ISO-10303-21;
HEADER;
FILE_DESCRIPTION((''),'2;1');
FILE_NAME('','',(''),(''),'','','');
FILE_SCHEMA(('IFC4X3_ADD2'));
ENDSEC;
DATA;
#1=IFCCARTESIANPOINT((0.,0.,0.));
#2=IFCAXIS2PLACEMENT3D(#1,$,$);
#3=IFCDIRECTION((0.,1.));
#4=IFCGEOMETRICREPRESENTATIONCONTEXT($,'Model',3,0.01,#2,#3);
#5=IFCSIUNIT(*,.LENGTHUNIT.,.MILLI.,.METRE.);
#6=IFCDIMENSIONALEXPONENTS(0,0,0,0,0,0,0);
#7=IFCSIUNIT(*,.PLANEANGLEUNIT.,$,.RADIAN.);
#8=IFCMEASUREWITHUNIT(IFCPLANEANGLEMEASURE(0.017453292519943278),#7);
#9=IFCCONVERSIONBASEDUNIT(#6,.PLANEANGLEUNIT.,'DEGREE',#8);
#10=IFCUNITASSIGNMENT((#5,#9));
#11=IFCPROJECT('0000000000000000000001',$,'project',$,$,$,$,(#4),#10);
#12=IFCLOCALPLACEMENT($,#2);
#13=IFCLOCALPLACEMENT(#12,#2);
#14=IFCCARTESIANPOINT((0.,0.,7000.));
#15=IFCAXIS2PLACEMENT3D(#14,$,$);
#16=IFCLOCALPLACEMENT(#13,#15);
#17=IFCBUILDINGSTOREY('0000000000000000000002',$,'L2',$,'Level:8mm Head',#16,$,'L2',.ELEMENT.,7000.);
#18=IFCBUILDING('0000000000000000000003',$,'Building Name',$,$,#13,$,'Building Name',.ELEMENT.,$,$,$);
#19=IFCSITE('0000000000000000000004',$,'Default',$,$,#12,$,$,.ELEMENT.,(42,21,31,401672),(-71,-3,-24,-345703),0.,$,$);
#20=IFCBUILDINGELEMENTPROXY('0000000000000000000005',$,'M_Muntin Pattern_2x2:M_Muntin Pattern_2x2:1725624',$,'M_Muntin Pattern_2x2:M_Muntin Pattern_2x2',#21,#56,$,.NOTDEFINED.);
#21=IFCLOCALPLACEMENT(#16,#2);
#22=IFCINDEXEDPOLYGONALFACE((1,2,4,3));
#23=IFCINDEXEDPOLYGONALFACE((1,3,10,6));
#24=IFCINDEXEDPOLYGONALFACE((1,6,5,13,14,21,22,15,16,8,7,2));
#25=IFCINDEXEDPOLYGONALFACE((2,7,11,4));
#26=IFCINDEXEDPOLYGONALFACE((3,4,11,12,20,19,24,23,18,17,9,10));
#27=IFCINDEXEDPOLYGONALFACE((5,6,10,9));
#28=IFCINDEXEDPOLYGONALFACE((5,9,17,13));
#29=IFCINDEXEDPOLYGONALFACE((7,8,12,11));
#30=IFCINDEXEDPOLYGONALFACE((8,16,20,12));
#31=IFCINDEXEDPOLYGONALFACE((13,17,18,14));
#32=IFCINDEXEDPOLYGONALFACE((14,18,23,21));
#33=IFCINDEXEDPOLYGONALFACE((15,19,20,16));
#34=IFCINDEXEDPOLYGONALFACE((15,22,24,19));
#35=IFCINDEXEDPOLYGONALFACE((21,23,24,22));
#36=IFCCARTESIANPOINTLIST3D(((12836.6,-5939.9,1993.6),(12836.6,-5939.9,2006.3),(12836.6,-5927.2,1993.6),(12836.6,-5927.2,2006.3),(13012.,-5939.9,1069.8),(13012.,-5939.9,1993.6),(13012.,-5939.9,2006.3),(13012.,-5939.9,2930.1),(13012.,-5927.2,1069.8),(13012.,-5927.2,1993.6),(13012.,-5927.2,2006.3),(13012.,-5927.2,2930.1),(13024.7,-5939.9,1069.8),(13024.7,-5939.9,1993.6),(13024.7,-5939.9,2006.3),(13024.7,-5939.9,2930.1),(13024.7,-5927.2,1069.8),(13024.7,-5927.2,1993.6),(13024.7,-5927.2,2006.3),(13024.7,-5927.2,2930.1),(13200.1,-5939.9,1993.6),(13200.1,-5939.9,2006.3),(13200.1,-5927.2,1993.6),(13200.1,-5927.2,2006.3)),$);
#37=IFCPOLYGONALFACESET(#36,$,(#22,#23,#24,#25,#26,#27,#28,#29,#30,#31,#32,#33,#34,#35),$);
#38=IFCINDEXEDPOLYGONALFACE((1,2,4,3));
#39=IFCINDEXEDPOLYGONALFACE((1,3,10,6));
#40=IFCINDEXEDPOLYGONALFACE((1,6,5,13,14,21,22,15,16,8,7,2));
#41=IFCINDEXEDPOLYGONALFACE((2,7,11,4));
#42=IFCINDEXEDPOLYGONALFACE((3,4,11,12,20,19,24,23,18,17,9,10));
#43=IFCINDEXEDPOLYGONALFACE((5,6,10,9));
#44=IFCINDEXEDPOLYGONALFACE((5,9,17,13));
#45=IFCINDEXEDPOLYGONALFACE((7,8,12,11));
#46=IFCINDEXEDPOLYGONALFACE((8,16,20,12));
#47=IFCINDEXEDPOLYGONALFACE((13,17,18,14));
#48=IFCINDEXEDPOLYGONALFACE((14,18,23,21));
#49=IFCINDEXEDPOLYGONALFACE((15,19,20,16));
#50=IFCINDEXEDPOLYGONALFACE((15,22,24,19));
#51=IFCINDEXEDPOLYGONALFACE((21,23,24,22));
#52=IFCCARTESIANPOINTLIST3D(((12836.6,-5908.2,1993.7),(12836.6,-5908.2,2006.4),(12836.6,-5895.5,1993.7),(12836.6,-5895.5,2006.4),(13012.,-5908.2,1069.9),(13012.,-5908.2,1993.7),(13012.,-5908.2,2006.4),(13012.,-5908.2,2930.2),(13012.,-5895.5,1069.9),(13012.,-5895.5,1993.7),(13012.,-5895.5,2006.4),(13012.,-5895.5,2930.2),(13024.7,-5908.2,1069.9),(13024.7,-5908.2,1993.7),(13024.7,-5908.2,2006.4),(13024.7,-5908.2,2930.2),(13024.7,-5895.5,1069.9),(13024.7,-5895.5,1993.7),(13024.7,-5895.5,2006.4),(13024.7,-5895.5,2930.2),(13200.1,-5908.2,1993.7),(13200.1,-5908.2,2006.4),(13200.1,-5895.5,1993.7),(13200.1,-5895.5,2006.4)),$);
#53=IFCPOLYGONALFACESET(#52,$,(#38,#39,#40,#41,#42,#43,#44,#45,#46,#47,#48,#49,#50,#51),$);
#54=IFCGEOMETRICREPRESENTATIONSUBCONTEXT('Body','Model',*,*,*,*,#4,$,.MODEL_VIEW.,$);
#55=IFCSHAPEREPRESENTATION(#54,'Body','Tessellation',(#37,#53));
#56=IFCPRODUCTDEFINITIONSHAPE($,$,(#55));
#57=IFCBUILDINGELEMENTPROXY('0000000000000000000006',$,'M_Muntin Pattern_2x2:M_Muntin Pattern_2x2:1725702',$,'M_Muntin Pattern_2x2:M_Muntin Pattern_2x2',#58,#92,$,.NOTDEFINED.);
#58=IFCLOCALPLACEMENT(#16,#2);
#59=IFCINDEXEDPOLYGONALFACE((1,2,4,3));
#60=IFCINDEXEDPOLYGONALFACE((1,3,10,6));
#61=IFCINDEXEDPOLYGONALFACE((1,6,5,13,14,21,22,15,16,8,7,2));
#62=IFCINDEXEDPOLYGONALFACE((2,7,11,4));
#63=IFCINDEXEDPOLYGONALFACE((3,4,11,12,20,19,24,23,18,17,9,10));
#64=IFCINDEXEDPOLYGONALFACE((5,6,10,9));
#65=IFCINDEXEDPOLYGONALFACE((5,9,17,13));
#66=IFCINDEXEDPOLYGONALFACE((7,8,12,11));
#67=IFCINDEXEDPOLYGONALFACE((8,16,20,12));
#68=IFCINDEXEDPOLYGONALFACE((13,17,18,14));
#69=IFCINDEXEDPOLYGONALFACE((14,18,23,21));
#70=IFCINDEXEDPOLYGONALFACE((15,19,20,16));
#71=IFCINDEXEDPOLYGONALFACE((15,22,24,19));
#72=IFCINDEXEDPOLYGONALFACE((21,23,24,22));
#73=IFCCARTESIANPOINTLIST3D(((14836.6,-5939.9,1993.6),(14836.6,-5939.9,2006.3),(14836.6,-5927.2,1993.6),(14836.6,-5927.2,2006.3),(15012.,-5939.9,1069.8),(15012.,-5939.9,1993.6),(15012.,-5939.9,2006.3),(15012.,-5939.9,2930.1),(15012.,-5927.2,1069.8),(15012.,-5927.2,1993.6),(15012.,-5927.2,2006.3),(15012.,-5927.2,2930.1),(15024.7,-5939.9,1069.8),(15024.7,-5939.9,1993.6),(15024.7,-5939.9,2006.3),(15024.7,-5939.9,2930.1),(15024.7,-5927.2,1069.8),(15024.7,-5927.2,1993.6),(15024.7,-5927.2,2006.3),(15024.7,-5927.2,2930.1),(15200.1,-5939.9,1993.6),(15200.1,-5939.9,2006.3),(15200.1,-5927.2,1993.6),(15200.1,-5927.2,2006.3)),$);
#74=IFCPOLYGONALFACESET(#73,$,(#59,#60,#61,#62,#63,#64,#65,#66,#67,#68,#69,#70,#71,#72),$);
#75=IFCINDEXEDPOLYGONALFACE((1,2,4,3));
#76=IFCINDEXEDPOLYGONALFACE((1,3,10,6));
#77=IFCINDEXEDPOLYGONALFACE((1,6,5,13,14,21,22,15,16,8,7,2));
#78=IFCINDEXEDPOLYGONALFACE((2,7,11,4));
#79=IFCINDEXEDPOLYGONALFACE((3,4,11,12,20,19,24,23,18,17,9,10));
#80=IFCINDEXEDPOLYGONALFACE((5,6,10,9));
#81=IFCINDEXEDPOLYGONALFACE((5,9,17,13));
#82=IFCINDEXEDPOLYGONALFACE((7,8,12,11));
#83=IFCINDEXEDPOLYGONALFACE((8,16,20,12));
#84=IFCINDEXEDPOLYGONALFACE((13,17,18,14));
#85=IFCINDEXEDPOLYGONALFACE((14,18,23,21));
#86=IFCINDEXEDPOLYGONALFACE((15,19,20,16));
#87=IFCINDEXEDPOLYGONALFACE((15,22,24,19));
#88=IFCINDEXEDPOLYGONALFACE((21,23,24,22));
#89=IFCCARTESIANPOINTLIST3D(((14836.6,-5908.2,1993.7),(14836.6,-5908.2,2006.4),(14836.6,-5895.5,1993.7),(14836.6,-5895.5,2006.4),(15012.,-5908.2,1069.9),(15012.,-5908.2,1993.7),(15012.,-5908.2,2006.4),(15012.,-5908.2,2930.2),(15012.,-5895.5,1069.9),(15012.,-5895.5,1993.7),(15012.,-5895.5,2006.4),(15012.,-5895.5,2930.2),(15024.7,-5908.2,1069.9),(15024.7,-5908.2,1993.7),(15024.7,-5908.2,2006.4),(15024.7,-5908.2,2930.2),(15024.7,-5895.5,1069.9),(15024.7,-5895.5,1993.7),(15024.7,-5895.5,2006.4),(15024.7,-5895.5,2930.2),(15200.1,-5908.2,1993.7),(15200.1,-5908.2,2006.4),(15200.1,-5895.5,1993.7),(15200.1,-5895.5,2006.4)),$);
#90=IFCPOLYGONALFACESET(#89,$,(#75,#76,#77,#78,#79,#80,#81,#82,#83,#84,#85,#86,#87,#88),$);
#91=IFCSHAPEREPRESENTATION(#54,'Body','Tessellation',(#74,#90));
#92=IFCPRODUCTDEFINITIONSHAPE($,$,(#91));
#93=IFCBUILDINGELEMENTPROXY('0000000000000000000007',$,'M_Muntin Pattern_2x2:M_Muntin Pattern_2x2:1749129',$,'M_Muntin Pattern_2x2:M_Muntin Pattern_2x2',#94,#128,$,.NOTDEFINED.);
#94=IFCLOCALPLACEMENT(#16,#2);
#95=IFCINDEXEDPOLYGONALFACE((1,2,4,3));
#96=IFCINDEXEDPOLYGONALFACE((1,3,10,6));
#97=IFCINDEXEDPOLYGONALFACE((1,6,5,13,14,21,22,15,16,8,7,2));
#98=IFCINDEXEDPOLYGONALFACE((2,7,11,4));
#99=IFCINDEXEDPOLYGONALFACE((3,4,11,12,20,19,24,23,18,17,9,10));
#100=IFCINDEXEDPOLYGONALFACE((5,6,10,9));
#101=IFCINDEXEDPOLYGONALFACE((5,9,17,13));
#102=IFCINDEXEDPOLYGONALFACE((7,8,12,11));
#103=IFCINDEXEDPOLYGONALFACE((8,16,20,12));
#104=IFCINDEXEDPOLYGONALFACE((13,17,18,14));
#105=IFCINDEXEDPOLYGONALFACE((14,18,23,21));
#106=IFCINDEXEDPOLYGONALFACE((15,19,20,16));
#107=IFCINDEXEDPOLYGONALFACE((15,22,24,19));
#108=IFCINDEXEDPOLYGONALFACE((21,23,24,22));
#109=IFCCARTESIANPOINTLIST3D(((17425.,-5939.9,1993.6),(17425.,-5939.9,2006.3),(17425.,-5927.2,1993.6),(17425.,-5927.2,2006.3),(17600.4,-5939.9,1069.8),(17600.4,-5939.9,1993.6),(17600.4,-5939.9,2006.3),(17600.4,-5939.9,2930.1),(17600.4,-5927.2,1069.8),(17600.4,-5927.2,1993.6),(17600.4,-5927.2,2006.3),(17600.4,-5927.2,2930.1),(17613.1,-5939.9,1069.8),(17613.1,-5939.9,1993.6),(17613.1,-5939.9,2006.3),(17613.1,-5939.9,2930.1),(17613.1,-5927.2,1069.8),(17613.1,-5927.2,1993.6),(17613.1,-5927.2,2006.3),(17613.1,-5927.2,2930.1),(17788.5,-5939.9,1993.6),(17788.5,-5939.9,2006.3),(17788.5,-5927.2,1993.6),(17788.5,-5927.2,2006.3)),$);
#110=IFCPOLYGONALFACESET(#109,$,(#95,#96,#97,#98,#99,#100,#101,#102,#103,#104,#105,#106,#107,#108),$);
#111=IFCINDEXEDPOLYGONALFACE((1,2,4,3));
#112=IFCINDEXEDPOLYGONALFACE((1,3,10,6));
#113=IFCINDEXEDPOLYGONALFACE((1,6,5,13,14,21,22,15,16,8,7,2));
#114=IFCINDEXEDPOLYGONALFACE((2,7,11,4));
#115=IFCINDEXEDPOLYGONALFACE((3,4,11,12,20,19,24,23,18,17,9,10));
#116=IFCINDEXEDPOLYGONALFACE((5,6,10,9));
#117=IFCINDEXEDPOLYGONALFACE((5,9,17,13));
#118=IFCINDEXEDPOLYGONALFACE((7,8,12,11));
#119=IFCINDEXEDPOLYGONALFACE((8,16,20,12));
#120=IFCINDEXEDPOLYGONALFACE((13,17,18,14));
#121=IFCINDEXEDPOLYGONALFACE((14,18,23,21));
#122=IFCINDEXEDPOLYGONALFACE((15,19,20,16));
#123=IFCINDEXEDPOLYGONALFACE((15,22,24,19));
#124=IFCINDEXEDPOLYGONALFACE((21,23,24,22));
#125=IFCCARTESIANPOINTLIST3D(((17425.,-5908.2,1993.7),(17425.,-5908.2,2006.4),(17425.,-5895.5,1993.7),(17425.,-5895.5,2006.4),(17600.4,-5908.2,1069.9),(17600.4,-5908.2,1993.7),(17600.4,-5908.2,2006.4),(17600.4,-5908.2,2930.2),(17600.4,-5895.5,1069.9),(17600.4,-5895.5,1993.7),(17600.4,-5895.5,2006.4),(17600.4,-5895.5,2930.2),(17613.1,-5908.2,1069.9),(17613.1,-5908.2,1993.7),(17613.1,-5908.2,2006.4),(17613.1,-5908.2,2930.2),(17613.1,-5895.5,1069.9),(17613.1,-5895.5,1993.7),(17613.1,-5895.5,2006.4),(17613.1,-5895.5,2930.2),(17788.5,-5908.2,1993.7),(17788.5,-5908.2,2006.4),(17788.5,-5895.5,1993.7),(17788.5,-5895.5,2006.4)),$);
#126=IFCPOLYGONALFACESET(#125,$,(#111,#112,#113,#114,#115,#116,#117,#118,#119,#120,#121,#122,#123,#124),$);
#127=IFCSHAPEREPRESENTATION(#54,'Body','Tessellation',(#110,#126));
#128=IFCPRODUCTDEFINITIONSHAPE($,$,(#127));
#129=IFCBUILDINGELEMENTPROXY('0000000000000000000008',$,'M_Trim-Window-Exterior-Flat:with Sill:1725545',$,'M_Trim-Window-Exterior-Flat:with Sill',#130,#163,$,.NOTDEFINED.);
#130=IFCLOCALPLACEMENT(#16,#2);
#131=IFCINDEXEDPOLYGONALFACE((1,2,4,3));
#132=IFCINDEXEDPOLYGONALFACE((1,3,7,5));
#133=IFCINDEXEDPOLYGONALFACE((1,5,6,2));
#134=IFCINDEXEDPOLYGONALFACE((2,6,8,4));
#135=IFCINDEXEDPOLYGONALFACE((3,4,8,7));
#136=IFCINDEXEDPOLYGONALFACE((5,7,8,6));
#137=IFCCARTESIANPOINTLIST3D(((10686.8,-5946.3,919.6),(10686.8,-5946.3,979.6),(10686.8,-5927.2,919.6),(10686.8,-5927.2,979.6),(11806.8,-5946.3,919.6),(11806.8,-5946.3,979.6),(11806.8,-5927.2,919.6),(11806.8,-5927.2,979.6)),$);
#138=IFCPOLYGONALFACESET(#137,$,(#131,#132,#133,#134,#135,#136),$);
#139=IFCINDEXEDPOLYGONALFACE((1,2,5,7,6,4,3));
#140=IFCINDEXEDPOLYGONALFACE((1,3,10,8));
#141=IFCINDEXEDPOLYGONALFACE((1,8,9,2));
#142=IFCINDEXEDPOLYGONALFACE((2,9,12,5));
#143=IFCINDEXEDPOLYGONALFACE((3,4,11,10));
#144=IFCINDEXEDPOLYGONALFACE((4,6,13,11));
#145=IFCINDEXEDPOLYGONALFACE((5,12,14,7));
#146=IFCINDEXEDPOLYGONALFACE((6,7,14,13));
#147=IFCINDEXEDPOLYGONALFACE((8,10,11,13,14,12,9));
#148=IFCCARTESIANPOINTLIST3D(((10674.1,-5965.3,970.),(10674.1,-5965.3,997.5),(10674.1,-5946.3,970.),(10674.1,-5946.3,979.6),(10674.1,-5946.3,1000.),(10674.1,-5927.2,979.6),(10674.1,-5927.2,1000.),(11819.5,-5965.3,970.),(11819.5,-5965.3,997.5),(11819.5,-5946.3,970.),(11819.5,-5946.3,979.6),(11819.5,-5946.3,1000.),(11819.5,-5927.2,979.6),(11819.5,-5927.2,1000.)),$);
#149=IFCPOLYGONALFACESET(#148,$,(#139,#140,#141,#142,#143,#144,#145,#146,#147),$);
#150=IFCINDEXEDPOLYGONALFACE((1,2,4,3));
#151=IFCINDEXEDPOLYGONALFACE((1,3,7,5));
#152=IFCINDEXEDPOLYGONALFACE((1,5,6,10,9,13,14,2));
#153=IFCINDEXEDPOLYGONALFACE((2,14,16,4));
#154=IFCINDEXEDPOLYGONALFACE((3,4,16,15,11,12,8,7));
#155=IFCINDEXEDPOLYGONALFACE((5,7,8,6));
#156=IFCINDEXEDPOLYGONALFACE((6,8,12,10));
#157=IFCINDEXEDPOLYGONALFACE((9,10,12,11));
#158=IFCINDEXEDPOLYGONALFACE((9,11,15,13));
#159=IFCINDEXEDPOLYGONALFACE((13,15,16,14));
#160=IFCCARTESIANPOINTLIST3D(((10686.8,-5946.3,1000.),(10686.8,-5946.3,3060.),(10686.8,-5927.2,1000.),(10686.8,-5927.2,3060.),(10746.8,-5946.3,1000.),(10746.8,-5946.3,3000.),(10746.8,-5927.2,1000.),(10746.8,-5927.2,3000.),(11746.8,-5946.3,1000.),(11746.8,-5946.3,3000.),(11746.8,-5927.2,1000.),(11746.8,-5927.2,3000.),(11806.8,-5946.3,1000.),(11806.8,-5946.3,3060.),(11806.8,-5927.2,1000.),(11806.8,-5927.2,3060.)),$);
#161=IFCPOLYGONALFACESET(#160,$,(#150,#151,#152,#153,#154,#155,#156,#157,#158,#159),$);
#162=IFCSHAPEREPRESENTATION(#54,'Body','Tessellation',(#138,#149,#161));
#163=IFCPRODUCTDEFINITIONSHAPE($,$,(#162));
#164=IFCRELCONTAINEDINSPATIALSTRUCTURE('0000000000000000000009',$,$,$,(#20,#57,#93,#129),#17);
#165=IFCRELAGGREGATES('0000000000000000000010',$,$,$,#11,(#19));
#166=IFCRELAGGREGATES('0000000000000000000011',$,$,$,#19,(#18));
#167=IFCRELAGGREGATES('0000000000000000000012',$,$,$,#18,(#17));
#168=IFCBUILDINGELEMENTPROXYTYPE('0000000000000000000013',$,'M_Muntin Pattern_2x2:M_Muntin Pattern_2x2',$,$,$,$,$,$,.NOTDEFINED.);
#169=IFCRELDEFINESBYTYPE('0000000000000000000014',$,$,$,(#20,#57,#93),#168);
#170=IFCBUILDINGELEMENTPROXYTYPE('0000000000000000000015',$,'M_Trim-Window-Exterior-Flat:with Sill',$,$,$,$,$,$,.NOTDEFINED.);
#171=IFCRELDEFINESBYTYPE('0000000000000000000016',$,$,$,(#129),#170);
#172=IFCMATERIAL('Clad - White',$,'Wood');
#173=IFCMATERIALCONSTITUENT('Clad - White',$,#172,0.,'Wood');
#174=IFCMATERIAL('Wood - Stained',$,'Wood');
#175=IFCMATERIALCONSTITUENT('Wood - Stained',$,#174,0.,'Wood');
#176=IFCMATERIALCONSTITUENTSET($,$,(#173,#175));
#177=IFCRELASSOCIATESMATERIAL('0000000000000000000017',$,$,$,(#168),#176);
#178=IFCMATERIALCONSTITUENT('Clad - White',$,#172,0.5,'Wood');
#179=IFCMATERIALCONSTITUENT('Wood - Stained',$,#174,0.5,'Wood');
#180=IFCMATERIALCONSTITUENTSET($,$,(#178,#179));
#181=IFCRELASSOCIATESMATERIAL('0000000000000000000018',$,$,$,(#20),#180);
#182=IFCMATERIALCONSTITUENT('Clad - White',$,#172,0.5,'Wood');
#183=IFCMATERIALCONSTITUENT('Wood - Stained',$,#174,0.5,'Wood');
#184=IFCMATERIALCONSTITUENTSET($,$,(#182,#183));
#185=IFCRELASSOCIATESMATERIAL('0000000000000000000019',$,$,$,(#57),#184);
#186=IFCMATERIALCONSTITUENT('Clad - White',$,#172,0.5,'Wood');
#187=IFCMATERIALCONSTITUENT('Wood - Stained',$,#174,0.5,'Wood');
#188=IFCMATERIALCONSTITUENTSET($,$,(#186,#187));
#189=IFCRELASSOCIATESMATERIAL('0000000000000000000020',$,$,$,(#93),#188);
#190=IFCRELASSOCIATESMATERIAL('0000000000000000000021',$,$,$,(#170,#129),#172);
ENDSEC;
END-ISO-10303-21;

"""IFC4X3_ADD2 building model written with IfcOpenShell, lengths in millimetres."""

from ifc_helpers import new_model, entity, si_unit, converted_unit, direction, frame, frame_2d, origin, place, context, subcontext, project, spatial, polyline, rectangle, outline, extrude, source, transform, mapped, material, constituent, constituent_set, type_object, type_shapes, element, save


model = new_model("IFC4X3_ADD2")

# Units and contexts
model_context = context("Model", 3, precision=0.01, world=origin(), true_north=direction((0.0, 1.0)))
body_context = subcontext(model_context, "Body", "Model", "MODEL_VIEW")
ifc_project = project(units=[si_unit("LENGTHUNIT", "METRE", prefix="MILLI"), converted_unit("PLANEANGLEUNIT", "DEGREE", entity("IfcPlaneAngleMeasure", 0.017453292519943278), si_unit("PLANEANGLEUNIT", "RADIAN"), dimensions=[0, 0, 0, 0, 0, 0, 0])], contexts=[model_context])

# Site, building, storey
site_placement = place(None, origin())
site = spatial("IfcSite", under=ifc_project, at=site_placement, Name="Default", CompositionType="ELEMENT", RefLatitude=(42, 21, 31, 401672), RefLongitude=(-71, -3, -24, -345703), RefElevation=0.0)
building_placement = place(site_placement, origin())
building = spatial("IfcBuilding", under=site, at=building_placement, Name="Building Name", LongName="Building Name", CompositionType="ELEMENT")
storey_placement = place(building_placement, frame((0.0, 0.0, 7000.0)))
storey = spatial("IfcBuildingStorey", under=building, at=storey_placement, Name="L2", ObjectType="Level:8mm Head", LongName="L2", CompositionType="ELEMENT", Elevation=7000.0)

# Building element proxies
ifc_material_1 = material(Name="Clad - White", Category="Wood")
ifc_material_2 = material(Name="Wood - Stained", Category="Wood")
ifc_constituent_1 = constituent(ifc_material_1, Name="Clad - White", Category="Wood", fraction=0.5)
ifc_constituent_2 = constituent(ifc_material_2, Name="Wood - Stained", Category="Wood", fraction=0.5)
ifc_constituent_set_1 = constituent_set(constituents=[ifc_constituent_1, ifc_constituent_2])
ifc_constituent_3 = constituent(ifc_material_1, Name="Clad - White", Category="Wood", fraction=0.0)
ifc_constituent_4 = constituent(ifc_material_2, Name="Wood - Stained", Category="Wood", fraction=0.0)
ifc_constituent_set_2 = constituent_set(constituents=[ifc_constituent_3, ifc_constituent_4])
building_element_proxy_type_1 = type_object("IfcBuildingElementProxyType", Name="M_Muntin Pattern_2x2:M_Muntin Pattern_2x2", PredefinedType="NOTDEFINED", material=ifc_constituent_set_2)
shared_shape_1 = source(origin(), body_context, "Body", "SweptSolid", [
    extrude(outline(polyline([(6.4, -6.4), (930.1, -6.4), (930.1, 6.3), (6.4, 6.3), (6.4, 181.7), (-6.3, 181.7), (-6.3, 6.3), (-930.2, 6.3), (-930.2, -6.4), (-6.3, -6.4), (-6.3, -181.7), (6.4, -181.7), (6.4, -6.4)])), frame((0.0, -22.2, 930.1), z_axis=(0.0, 1.0, 0.0), x_axis=(0.0, 0.0, 1.0)), (0.0, 0.0, 1.0), 12.7),
    extrude(outline(polyline([(6.4, -6.4), (930.2, -6.4), (930.2, 6.3), (6.4, 6.3), (6.4, 181.7), (-6.3, 181.7), (-6.3, 6.3), (-930.2, 6.3), (-930.2, -6.4), (-6.3, -6.4), (-6.3, -181.7), (6.4, -181.7), (6.4, -6.4)])), frame((0.0, 9.5, 930.2), z_axis=(0.0, 1.0, 0.0), x_axis=(0.0, 0.0, 1.0)), (0.0, 0.0, 1.0), 12.7),
])
type_shapes(building_element_proxy_type_1, [shared_shape_1])
proxy_1_placement = place(storey_placement, frame((13018.4, -5917.7, 1069.9)))
element("IfcBuildingElementProxy", 1, at=proxy_1_placement, inside=storey, type_object=building_element_proxy_type_1, material=ifc_constituent_set_1, Name="M_Muntin Pattern_2x2:M_Muntin Pattern_2x2:1725624", ObjectType="M_Muntin Pattern_2x2:M_Muntin Pattern_2x2", PredefinedType="NOTDEFINED", context=body_context, shape_type="MappedRepresentation", body=[
    mapped(shared_shape_1, transform((0.0, 0.0, 0.0), scale=1.0)),
])
ifc_constituent_5 = constituent(ifc_material_1, Name="Clad - White", Category="Wood", fraction=0.5)
ifc_constituent_6 = constituent(ifc_material_2, Name="Wood - Stained", Category="Wood", fraction=0.5)
ifc_constituent_set_3 = constituent_set(constituents=[ifc_constituent_5, ifc_constituent_6])
proxy_2_placement = place(storey_placement, frame((15018.4, -5917.7, 1069.9)))
element("IfcBuildingElementProxy", 2, at=proxy_2_placement, inside=storey, type_object=building_element_proxy_type_1, material=ifc_constituent_set_3, Name="M_Muntin Pattern_2x2:M_Muntin Pattern_2x2:1725702", ObjectType="M_Muntin Pattern_2x2:M_Muntin Pattern_2x2", PredefinedType="NOTDEFINED", context=body_context, shape_type="MappedRepresentation", body=[
    mapped(shared_shape_1, transform((0.0, 0.0, 0.0), scale=1.0)),
])
ifc_constituent_7 = constituent(ifc_material_1, Name="Clad - White", Category="Wood", fraction=0.5)
ifc_constituent_8 = constituent(ifc_material_2, Name="Wood - Stained", Category="Wood", fraction=0.5)
ifc_constituent_set_4 = constituent_set(constituents=[ifc_constituent_7, ifc_constituent_8])
proxy_3_placement = place(storey_placement, frame((17606.7, -5917.7, 1069.9)))
element("IfcBuildingElementProxy", 3, at=proxy_3_placement, inside=storey, type_object=building_element_proxy_type_1, material=ifc_constituent_set_4, Name="M_Muntin Pattern_2x2:M_Muntin Pattern_2x2:1749129", ObjectType="M_Muntin Pattern_2x2:M_Muntin Pattern_2x2", PredefinedType="NOTDEFINED", context=body_context, shape_type="MappedRepresentation", body=[
    mapped(shared_shape_1, transform((0.0, 0.0, 0.0), scale=1.0)),
])
building_element_proxy_type_2 = type_object("IfcBuildingElementProxyType", Name="M_Trim-Window-Exterior-Flat:with Sill", PredefinedType="NOTDEFINED", material=ifc_material_1)
shared_shape_2 = source(origin(), body_context, "Body", "SweptSolid", [
    extrude(rectangle(XDim=1120.0, YDim=60.0, at=frame_2d((0.0, 0.0), x_axis=(1.0, 0.0))), frame((0.0, -2050.4, 0.0), z_axis=(0.0, 0.0, 1.0), x_axis=(-1.0, 0.0, 0.0)), (0.0, 0.0, 1.0), 19.0),
    extrude(outline(polyline([(-19.0, -15.2), (0.0, -15.2), (0.0, -5.7), (19.0, -5.7), (19.0, 14.8), (0.0, 14.8), (-19.0, 12.3), (-19.0, -15.2)])), frame((-572.7, -2014.8, 19.0), z_axis=(1.0, 0.0, 0.0), x_axis=(0.0, 0.0, -1.0)), (0.0, 0.0, 1.0), 1145.4),
    extrude(outline(polyline([(-1045.0, -560.0), (1015.0, -560.0), (1015.0, -500.0), (-985.0, -500.0), (-985.0, 500.0), (1015.0, 500.0), (1015.0, 560.0), (-1045.0, 560.0), (-1045.0, -560.0)])), frame((0.0, -985.0, 0.0), z_axis=(0.0, 0.0, 1.0), x_axis=(0.0, -1.0, 0.0)), (0.0, 0.0, 1.0), 19.0),
])
type_shapes(building_element_proxy_type_2, [shared_shape_2])
for number, where, z_axis, x_axis, name in (
    (4, (11246.8, -5927.2, 3000.0), (0.0, -1.0, 0.0), (1.0, 0.0, 0.0), "M_Trim-Window-Exterior-Flat:with Sill:1725545"),
):
    element("IfcBuildingElementProxy", number, at=place(storey_placement, frame(where, z_axis=z_axis, x_axis=x_axis)), inside=storey, type_object=building_element_proxy_type_2, material=ifc_material_1, Name=name, ObjectType="M_Trim-Window-Exterior-Flat:with Sill", PredefinedType="NOTDEFINED", context=body_context, shape_type="MappedRepresentation", body=[
        mapped(shared_shape_2, transform((0.0, 0.0, 0.0), scale=1.0)),
    ])

save(model, "model.ifc")
